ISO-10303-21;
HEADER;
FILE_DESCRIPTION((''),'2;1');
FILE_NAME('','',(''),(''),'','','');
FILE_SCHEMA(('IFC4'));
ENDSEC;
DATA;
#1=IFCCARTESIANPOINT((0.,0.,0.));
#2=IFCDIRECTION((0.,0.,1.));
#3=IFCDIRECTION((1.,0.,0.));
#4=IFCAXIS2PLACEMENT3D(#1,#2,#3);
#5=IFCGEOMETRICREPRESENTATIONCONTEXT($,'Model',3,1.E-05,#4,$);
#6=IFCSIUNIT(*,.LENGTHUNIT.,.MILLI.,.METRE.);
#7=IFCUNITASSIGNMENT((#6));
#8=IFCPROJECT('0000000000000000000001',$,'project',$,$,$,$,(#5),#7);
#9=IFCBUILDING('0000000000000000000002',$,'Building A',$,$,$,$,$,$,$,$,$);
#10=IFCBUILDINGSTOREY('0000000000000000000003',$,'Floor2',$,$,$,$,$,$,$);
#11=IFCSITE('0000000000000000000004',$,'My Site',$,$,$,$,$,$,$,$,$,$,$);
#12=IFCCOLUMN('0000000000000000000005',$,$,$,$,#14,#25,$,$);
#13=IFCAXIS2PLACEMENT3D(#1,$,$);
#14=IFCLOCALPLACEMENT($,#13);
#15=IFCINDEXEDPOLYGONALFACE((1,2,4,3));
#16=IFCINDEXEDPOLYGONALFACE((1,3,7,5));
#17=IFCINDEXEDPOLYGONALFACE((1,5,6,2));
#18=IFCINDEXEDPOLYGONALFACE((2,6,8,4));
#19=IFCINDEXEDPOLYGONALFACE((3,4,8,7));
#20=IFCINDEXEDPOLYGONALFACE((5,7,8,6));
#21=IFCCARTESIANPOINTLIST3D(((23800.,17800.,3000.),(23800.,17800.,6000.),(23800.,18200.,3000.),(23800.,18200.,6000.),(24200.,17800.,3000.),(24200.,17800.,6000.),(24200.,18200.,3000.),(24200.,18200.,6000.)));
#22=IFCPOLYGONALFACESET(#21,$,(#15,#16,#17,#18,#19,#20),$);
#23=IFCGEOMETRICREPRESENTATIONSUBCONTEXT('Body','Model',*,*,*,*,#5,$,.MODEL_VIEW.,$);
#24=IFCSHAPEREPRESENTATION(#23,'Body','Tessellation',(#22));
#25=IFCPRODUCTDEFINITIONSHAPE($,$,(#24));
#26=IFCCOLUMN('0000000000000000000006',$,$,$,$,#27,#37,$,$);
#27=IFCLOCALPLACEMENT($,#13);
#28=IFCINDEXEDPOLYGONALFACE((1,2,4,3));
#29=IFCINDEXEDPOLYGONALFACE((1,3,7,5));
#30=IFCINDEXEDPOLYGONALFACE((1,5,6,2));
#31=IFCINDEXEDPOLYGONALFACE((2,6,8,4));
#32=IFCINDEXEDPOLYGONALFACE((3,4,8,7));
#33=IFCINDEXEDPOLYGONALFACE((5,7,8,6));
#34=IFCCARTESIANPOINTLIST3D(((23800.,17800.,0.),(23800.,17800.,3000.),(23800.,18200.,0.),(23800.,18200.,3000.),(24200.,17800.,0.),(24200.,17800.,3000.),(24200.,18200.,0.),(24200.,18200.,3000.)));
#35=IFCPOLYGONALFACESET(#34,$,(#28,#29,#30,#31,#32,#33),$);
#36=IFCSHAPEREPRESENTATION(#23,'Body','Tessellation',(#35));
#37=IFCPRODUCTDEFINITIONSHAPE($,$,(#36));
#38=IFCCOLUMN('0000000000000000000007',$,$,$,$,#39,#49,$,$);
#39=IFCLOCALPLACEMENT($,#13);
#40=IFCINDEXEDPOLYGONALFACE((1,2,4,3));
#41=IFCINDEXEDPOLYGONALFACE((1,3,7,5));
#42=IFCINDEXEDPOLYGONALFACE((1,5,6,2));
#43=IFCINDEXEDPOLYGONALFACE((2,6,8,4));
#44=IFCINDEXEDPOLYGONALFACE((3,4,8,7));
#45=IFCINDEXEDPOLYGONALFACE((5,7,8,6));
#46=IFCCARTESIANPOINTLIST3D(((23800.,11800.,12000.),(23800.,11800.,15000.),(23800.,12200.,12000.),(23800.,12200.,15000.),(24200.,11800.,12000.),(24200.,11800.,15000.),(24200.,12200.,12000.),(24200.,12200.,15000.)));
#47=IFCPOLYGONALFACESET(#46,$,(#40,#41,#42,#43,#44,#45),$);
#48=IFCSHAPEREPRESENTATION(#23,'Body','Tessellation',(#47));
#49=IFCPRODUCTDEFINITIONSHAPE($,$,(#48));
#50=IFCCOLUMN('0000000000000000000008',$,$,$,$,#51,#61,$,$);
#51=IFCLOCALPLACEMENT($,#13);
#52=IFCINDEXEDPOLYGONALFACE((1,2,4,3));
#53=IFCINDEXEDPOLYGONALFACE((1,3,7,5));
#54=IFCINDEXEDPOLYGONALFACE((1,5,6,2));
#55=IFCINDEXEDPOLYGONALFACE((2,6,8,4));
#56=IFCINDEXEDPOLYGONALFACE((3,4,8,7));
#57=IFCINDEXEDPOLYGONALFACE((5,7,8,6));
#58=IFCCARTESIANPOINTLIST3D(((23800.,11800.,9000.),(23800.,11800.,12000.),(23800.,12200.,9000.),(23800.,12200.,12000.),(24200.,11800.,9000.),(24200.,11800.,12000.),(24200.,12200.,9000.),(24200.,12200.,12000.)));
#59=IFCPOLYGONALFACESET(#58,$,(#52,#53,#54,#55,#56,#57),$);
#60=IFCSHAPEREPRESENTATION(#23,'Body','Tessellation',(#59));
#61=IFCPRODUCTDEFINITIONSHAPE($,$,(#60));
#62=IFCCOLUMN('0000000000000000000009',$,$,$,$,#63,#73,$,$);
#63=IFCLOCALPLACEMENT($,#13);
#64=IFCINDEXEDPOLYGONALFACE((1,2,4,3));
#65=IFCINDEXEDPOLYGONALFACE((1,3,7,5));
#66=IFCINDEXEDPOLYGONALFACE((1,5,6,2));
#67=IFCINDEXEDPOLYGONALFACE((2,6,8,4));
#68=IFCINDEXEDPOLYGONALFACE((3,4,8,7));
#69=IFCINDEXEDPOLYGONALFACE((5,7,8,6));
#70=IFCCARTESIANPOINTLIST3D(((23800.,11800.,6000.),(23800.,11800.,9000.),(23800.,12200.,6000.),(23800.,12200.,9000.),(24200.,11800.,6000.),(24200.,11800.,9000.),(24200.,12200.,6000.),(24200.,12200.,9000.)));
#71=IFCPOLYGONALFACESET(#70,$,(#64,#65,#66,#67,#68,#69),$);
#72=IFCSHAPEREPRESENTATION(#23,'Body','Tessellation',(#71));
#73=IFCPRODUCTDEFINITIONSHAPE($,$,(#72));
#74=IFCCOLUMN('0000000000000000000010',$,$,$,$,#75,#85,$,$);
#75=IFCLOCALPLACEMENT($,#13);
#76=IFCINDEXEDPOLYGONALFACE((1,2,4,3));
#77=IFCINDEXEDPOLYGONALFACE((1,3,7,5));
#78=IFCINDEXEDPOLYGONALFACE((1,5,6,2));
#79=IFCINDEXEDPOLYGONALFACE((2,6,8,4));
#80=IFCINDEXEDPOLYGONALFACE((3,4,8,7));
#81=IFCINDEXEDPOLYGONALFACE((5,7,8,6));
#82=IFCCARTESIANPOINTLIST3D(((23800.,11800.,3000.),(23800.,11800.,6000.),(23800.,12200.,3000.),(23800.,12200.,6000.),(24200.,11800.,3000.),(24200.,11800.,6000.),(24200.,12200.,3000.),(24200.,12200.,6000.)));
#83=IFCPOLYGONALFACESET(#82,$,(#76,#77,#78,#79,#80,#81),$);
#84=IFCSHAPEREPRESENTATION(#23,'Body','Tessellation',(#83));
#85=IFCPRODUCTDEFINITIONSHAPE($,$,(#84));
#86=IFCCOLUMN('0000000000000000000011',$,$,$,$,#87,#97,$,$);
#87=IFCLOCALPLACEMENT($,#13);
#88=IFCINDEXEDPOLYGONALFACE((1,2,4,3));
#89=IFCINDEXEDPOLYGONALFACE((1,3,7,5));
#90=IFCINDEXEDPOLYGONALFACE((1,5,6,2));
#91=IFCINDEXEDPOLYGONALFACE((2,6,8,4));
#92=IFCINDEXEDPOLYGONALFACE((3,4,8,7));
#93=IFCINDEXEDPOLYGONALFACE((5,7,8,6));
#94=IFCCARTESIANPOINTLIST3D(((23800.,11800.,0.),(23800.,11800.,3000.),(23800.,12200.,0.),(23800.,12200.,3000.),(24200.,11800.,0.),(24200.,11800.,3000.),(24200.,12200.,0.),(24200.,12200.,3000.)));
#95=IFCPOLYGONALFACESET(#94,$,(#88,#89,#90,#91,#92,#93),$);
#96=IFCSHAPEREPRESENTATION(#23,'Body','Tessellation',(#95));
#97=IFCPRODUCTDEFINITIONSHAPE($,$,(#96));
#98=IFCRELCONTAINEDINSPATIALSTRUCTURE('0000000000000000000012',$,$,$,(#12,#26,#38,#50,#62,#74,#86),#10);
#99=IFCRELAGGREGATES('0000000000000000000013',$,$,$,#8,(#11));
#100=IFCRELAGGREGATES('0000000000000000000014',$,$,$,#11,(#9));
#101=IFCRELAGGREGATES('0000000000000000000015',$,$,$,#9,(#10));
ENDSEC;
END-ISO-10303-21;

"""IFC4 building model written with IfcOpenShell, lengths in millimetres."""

from ifc_helpers import new_model, si_unit, frame, origin_with_axes, place, context, subcontext, project, spatial, line, indexed_curve, outline, extrude, element, save


model = new_model("IFC4")

# Units and contexts
model_context = context("Model", 3, precision=1e-05, world=origin_with_axes())
body_context = subcontext(model_context, "Body", "Model", "MODEL_VIEW")
ifc_project = project(units=[si_unit("LENGTHUNIT", "METRE", prefix="MILLI")], contexts=[model_context])

# Site, building, storey
site = spatial("IfcSite", under=ifc_project, Name="My Site")
building = spatial("IfcBuilding", under=site, Name="Building A")
storey = spatial("IfcBuildingStorey", under=building, Name="Floor2")

# Columns
for number, where, z_axis, x_axis in (
    (1, (24000.0, 18000.0, 3000.0), (0.0, 0.0, 1.0), (1.0, 0.0, 0.0)),
    (2, (24000.0, 18000.0, 0.0), (0.0, 0.0, 1.0), (1.0, 0.0, 0.0)),
    (3, (24000.0, 12000.0, 12000.0), (0.0, 0.0, 1.0), (1.0, 0.0, 0.0)),
    (4, (24000.0, 12000.0, 9000.0), (0.0, 0.0, 1.0), (1.0, 0.0, 0.0)),
    (5, (24000.0, 12000.0, 6000.0), (0.0, 0.0, 1.0), (1.0, 0.0, 0.0)),
    (6, (24000.0, 12000.0, 3000.0), (0.0, 0.0, 1.0), (1.0, 0.0, 0.0)),
    (7, (24000.0, 12000.0, 0.0), (0.0, 0.0, 1.0), (1.0, 0.0, 0.0)),
):
    element("IfcColumn", number, at=place(None, frame(where, z_axis=z_axis, x_axis=x_axis)), inside=storey, context=body_context, shape_type="SweptSolid", body=[
        extrude(outline(indexed_curve([(-200.0, -200.0), (200.0, -200.0), (200.0, 200.0), (-200.0, 200.0)], segments=[line(1, 2, 3, 4, 1)])), origin_with_axes(), (0.0, 0.0, 1.0), 3000.0),
    ])

save(model, "model.ifc")
